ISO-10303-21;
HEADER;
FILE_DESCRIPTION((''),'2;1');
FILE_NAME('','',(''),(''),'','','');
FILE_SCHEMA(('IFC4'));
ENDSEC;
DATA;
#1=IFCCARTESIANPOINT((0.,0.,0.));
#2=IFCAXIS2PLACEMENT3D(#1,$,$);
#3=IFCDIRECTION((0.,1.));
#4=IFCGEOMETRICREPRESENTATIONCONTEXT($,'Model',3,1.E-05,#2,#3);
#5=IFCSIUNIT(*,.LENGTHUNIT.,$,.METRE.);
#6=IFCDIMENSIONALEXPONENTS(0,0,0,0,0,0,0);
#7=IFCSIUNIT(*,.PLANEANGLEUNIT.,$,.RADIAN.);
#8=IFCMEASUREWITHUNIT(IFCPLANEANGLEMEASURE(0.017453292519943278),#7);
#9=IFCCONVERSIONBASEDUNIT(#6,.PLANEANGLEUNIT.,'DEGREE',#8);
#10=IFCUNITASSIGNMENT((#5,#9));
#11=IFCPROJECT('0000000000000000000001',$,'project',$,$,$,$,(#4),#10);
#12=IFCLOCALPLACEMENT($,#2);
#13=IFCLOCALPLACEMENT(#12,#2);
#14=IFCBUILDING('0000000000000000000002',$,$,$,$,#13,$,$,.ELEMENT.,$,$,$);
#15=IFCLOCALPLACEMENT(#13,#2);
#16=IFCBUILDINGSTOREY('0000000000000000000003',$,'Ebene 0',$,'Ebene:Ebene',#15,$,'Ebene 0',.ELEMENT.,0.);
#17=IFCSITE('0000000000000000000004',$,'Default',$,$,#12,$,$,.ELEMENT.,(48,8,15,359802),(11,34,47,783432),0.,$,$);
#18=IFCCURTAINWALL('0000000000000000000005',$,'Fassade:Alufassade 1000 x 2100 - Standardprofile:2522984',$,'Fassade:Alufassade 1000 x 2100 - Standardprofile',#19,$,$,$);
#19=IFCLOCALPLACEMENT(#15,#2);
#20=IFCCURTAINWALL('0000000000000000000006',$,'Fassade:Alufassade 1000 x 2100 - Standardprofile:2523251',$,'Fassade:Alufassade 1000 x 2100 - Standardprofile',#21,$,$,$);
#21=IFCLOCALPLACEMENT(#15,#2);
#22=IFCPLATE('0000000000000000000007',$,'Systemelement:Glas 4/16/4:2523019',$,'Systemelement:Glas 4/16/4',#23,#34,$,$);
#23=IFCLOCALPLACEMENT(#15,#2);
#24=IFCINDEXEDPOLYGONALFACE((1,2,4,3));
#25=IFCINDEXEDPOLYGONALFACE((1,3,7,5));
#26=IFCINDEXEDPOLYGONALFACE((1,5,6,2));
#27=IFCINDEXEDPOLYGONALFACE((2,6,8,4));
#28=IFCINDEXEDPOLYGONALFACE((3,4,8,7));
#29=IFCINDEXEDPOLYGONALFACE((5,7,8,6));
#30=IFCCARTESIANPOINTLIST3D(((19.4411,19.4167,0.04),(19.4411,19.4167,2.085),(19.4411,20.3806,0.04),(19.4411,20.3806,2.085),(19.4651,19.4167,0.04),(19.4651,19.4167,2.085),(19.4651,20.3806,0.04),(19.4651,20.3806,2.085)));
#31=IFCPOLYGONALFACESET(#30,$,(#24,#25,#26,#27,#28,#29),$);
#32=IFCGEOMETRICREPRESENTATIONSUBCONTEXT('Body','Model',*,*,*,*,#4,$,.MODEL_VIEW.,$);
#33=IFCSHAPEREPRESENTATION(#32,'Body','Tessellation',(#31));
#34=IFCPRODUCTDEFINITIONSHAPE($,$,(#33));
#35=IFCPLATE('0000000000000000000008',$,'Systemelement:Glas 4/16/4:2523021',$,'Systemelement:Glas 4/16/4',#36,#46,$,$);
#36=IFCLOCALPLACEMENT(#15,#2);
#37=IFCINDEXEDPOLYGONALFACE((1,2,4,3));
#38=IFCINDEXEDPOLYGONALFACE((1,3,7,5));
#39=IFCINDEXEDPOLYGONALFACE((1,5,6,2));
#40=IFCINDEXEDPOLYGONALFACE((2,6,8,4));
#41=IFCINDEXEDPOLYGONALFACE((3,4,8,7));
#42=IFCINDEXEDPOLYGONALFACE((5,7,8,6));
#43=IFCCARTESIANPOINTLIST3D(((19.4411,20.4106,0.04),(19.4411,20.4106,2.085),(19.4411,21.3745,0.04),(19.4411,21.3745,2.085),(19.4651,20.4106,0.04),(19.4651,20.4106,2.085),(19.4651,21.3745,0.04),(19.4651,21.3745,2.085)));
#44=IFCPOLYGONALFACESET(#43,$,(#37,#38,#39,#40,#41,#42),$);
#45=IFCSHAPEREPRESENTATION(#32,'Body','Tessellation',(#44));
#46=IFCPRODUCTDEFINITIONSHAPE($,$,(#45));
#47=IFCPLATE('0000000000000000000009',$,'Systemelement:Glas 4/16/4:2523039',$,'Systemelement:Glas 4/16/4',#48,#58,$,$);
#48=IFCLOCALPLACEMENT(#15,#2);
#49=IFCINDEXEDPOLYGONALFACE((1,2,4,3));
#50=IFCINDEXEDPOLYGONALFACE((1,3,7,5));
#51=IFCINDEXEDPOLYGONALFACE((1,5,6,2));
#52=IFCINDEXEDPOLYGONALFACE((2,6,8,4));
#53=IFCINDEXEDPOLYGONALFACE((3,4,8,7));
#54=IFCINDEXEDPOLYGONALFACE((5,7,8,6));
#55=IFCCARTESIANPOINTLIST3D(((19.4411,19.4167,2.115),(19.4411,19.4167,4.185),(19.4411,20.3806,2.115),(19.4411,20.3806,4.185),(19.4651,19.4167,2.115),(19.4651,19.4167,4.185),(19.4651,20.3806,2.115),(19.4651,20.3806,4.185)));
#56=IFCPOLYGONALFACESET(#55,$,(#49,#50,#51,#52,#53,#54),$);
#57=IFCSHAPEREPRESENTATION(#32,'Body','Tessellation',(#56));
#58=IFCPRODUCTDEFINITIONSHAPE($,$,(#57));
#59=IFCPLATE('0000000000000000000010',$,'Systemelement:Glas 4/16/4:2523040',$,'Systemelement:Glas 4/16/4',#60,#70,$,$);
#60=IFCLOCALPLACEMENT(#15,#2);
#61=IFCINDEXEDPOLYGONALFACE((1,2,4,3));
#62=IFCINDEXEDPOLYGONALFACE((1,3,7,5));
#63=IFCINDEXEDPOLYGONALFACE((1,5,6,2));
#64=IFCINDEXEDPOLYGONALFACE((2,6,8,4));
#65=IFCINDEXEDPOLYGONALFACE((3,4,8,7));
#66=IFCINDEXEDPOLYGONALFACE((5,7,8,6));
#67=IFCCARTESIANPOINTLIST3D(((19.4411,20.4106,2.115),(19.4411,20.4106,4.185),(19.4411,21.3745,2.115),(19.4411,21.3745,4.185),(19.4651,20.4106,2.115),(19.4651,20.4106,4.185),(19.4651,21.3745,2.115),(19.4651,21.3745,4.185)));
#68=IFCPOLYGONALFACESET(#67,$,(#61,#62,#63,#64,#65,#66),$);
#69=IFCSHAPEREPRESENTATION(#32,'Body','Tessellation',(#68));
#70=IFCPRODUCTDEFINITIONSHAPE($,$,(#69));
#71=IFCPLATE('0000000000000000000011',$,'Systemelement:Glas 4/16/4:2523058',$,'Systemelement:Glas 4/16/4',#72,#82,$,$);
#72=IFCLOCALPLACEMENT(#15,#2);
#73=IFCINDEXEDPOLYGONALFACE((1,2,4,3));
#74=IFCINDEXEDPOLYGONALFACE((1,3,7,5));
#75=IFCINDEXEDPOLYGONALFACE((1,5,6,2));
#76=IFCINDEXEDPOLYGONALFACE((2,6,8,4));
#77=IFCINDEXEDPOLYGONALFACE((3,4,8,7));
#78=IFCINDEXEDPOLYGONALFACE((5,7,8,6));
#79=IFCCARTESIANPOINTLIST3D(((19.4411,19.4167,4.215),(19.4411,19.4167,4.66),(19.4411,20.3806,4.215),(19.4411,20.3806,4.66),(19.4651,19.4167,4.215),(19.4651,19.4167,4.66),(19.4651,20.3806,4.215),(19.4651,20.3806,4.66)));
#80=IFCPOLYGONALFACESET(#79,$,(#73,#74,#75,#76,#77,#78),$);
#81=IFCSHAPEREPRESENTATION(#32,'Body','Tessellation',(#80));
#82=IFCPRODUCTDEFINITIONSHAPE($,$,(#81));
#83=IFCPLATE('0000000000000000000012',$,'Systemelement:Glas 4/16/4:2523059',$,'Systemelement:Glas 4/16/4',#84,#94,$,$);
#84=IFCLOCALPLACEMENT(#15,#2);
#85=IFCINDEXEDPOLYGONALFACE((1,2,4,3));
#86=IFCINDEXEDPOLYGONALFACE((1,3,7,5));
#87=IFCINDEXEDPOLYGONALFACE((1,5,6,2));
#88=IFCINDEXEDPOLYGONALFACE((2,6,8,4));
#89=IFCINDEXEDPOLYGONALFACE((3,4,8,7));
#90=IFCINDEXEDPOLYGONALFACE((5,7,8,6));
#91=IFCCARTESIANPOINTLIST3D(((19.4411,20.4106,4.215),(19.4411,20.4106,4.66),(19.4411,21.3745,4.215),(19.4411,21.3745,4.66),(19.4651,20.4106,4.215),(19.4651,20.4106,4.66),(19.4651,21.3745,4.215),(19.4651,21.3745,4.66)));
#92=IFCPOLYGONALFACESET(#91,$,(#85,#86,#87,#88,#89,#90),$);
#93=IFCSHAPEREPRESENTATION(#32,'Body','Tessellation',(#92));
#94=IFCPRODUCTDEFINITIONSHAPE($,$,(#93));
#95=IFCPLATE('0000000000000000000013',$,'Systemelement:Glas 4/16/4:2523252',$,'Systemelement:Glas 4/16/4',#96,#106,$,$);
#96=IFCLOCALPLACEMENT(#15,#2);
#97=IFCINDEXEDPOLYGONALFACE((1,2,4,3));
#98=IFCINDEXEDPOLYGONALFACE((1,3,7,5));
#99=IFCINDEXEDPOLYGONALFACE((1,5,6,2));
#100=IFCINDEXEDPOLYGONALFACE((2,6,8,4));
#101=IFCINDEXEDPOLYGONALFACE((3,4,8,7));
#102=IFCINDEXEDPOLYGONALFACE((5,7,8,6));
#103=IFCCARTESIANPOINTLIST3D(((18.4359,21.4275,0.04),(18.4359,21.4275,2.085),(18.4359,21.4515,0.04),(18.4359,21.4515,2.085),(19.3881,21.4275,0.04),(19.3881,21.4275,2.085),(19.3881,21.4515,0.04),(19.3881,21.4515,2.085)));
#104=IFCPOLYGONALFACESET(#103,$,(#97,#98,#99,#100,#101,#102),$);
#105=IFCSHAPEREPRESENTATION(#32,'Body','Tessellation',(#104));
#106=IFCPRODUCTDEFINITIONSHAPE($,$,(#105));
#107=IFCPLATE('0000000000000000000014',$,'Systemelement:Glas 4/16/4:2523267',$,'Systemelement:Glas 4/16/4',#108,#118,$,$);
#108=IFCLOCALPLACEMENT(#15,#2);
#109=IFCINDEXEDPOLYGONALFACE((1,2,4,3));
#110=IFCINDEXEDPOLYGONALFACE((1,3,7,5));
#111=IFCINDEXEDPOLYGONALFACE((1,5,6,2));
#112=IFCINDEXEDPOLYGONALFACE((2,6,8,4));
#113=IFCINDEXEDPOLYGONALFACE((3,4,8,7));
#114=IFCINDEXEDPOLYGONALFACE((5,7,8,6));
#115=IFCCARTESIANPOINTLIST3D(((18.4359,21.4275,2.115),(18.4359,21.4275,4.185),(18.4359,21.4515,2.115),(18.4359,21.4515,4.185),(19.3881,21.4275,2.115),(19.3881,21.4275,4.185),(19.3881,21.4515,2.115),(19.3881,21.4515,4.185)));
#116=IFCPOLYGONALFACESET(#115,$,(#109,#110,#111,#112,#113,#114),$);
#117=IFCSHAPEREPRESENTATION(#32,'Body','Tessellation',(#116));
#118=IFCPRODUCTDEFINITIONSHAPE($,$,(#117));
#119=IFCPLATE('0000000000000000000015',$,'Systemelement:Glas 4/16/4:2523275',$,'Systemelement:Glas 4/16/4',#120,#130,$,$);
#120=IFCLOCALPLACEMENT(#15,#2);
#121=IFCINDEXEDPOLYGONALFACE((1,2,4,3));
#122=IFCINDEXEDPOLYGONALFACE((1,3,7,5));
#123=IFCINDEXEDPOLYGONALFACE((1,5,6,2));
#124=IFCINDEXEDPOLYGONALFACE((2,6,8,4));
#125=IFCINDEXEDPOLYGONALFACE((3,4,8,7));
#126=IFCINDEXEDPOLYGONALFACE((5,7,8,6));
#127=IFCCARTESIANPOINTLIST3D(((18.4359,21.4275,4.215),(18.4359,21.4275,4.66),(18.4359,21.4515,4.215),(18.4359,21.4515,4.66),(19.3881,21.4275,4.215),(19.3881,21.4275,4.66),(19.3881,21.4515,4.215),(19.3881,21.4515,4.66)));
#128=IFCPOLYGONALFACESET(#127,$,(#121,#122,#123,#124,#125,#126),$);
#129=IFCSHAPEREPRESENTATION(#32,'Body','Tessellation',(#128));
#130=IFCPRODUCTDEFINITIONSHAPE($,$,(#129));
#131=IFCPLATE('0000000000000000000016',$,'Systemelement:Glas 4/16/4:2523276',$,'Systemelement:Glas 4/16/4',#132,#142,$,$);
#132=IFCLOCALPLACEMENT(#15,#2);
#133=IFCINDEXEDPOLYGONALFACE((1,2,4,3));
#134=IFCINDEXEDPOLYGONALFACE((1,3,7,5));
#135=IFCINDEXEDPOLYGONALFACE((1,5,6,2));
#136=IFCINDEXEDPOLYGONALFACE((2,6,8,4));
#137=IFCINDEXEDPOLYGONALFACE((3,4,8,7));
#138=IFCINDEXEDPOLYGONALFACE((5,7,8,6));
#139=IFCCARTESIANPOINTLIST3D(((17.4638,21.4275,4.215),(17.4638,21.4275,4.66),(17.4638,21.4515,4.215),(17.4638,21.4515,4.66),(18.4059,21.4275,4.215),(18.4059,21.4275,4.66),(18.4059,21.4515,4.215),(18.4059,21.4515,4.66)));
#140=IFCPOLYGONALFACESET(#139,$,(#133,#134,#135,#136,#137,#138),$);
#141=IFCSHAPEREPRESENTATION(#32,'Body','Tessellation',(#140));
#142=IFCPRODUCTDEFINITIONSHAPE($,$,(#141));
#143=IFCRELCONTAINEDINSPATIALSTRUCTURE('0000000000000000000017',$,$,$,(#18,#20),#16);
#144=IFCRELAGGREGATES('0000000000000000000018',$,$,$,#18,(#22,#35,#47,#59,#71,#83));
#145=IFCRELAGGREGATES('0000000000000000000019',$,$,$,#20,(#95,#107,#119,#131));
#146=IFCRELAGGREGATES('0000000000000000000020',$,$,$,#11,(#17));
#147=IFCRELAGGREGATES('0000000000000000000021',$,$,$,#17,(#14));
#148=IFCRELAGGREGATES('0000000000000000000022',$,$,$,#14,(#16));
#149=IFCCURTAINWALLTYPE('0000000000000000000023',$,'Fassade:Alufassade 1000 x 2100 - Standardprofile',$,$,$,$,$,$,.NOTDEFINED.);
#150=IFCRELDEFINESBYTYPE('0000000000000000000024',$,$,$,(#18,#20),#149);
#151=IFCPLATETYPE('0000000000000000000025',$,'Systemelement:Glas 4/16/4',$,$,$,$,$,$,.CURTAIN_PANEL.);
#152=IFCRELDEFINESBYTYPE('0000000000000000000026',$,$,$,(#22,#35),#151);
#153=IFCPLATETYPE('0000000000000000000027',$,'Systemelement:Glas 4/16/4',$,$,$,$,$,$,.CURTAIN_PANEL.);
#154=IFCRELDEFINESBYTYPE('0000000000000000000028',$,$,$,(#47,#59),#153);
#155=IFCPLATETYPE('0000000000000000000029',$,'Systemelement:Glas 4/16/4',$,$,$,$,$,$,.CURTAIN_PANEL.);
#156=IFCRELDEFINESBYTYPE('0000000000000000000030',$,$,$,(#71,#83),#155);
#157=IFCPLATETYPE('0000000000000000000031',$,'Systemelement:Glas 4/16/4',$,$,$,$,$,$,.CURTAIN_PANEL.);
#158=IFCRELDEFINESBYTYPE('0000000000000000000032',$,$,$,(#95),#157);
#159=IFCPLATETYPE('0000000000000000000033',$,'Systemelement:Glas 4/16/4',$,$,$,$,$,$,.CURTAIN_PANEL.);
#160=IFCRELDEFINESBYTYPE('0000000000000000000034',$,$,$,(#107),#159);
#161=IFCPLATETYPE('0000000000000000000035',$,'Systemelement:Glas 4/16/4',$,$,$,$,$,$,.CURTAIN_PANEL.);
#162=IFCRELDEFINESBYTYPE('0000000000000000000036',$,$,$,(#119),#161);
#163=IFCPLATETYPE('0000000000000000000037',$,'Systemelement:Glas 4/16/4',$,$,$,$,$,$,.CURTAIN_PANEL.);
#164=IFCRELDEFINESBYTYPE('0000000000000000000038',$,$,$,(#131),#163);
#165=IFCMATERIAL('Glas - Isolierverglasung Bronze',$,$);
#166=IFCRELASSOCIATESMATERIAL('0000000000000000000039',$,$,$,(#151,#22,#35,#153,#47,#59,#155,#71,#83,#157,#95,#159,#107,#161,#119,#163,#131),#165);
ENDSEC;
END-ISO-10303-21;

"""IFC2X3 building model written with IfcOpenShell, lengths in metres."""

from ifc_helpers import new_model, entity, si_unit, converted_unit, direction, frame, origin, origin_2d_with_axis, place, context, subcontext, project, spatial, rectangle, extrude, source, transform, mapped, material, type_object, type_shapes, element, aggregate, save


model = new_model("IFC2X3")

# Units and contexts
model_context = context("Model", 3, precision=1e-05, world=origin(), true_north=direction((0.0, 1.0)))
body_context = subcontext(model_context, "Body", "Model", "MODEL_VIEW")
ifc_project = project(units=[si_unit("LENGTHUNIT", "METRE"), converted_unit("PLANEANGLEUNIT", "DEGREE", entity("IfcPlaneAngleMeasure", 0.017453292519943278), si_unit("PLANEANGLEUNIT", "RADIAN"), dimensions=[0, 0, 0, 0, 0, 0, 0])], contexts=[model_context])

# Site, building, storey
site_placement = place(None, origin())
site = spatial("IfcSite", under=ifc_project, at=site_placement, Name="Default", CompositionType="ELEMENT", RefLatitude=(48, 8, 15, 359802), RefLongitude=(11, 34, 47, 783432), RefElevation=0.0)
building_placement = place(site_placement, origin())
building = spatial("IfcBuilding", under=site, at=building_placement, CompositionType="ELEMENT")
storey_placement = place(building_placement, origin())
storey = spatial("IfcBuildingStorey", under=building, at=storey_placement, Name="Ebene 0", ObjectType="Ebene:Ebene", LongName="Ebene 0", CompositionType="ELEMENT", Elevation=0.0)

# Curtain walls
curtain_wall_type = type_object("IfcCurtainWallType", Name="Fassade:Alufassade 1000 x 2100 - Standardprofile", PredefinedType="NOTDEFINED")
curtain_wall_1_placement = place(storey_placement, origin())
curtain_wall_1 = element("IfcCurtainWall", 1, at=curtain_wall_1_placement, inside=storey, type_object=curtain_wall_type, Name="Fassade:Alufassade 1000 x 2100 - Standardprofile:2522984", ObjectType="Fassade:Alufassade 1000 x 2100 - Standardprofile")
curtain_wall_2_placement = place(storey_placement, origin())
curtain_wall_2 = element("IfcCurtainWall", 2, at=curtain_wall_2_placement, inside=storey, type_object=curtain_wall_type, Name="Fassade:Alufassade 1000 x 2100 - Standardprofile:2523251", ObjectType="Fassade:Alufassade 1000 x 2100 - Standardprofile")

# Plates
ifc_material_1 = material(Name="Glas - Isolierverglasung Bronze")
plate_type_1 = type_object("IfcPlateType", Name="Systemelement:Glas 4/16/4", PredefinedType="CURTAIN_PANEL", material=ifc_material_1)
shared_shape_1 = source(origin(), body_context, "Body", "SweptSolid", [
    extrude(rectangle(XDim=0.024, YDim=0.9639, at=origin_2d_with_axis()), frame((0.0, 0.0, 0.0), z_axis=(0.0, 0.0, 1.0), x_axis=(0.0, 1.0, 0.0)), (0.0, 0.0, 1.0), 2.045),
])
type_shapes(plate_type_1, [shared_shape_1])
plate_1_placement = place(curtain_wall_1_placement, frame((19.4531, 19.8987, 0.04), z_axis=(0.0, 0.0, 1.0), x_axis=(0.0, 1.0, 0.0)))
plate_1 = element("IfcPlate", 3, at=plate_1_placement, type_object=plate_type_1, material=ifc_material_1, Name="Systemelement:Glas 4/16/4:2523019", ObjectType="Systemelement:Glas 4/16/4", context=body_context, shape_type="MappedRepresentation", body=[
    mapped(shared_shape_1, transform((0.0, 0.0, 0.0), scale=1.0)),
])
plate_2_placement = place(curtain_wall_1_placement, frame((19.4531, 20.8926, 0.04), z_axis=(0.0, 0.0, 1.0), x_axis=(0.0, 1.0, 0.0)))
plate_2 = element("IfcPlate", 4, at=plate_2_placement, type_object=plate_type_1, material=ifc_material_1, Name="Systemelement:Glas 4/16/4:2523021", ObjectType="Systemelement:Glas 4/16/4", context=body_context, shape_type="MappedRepresentation", body=[
    mapped(shared_shape_1, transform((0.0, 0.0, 0.0), scale=1.0)),
])
plate_type_2 = type_object("IfcPlateType", Name="Systemelement:Glas 4/16/4", PredefinedType="CURTAIN_PANEL", material=ifc_material_1)
shared_shape_2 = source(origin(), body_context, "Body", "SweptSolid", [
    extrude(rectangle(XDim=0.024, YDim=0.9639, at=origin_2d_with_axis()), frame((0.0, 0.0, 0.0), z_axis=(0.0, 0.0, 1.0), x_axis=(0.0, 1.0, 0.0)), (0.0, 0.0, 1.0), 2.07),
])
type_shapes(plate_type_2, [shared_shape_2])
plate_3_placement = place(curtain_wall_1_placement, frame((19.4531, 19.8987, 2.115), z_axis=(0.0, 0.0, 1.0), x_axis=(0.0, 1.0, 0.0)))
plate_3 = element("IfcPlate", 5, at=plate_3_placement, type_object=plate_type_2, material=ifc_material_1, Name="Systemelement:Glas 4/16/4:2523039", ObjectType="Systemelement:Glas 4/16/4", context=body_context, shape_type="MappedRepresentation", body=[
    mapped(shared_shape_2, transform((0.0, 0.0, 0.0), scale=1.0)),
])
plate_4_placement = place(curtain_wall_1_placement, frame((19.4531, 20.8926, 2.115), z_axis=(0.0, 0.0, 1.0), x_axis=(0.0, 1.0, 0.0)))
plate_4 = element("IfcPlate", 6, at=plate_4_placement, type_object=plate_type_2, material=ifc_material_1, Name="Systemelement:Glas 4/16/4:2523040", ObjectType="Systemelement:Glas 4/16/4", context=body_context, shape_type="MappedRepresentation", body=[
    mapped(shared_shape_2, transform((0.0, 0.0, 0.0), scale=1.0)),
])
plate_type_3 = type_object("IfcPlateType", Name="Systemelement:Glas 4/16/4", PredefinedType="CURTAIN_PANEL", material=ifc_material_1)
shared_shape_3 = source(origin(), body_context, "Body", "SweptSolid", [
    extrude(rectangle(XDim=0.024, YDim=0.9639, at=origin_2d_with_axis()), frame((0.0, 0.0, 0.0), z_axis=(0.0, 0.0, 1.0), x_axis=(0.0, 1.0, 0.0)), (0.0, 0.0, 1.0), 0.445),
])
type_shapes(plate_type_3, [shared_shape_3])
plate_5_placement = place(curtain_wall_1_placement, frame((19.4531, 19.8987, 4.215), z_axis=(0.0, 0.0, 1.0), x_axis=(0.0, 1.0, 0.0)))
plate_5 = element("IfcPlate", 7, at=plate_5_placement, type_object=plate_type_3, material=ifc_material_1, Name="Systemelement:Glas 4/16/4:2523058", ObjectType="Systemelement:Glas 4/16/4", context=body_context, shape_type="MappedRepresentation", body=[
    mapped(shared_shape_3, transform((0.0, 0.0, 0.0), scale=1.0)),
])
plate_6_placement = place(curtain_wall_1_placement, frame((19.4531, 20.8926, 4.215), z_axis=(0.0, 0.0, 1.0), x_axis=(0.0, 1.0, 0.0)))
plate_6 = element("IfcPlate", 8, at=plate_6_placement, type_object=plate_type_3, material=ifc_material_1, Name="Systemelement:Glas 4/16/4:2523059", ObjectType="Systemelement:Glas 4/16/4", context=body_context, shape_type="MappedRepresentation", body=[
    mapped(shared_shape_3, transform((0.0, 0.0, 0.0), scale=1.0)),
])
aggregate(curtain_wall_1, [plate_1, plate_2, plate_3, plate_4, plate_5, plate_6])
plate_type_4 = type_object("IfcPlateType", Name="Systemelement:Glas 4/16/4", PredefinedType="CURTAIN_PANEL", material=ifc_material_1)
shared_shape_4 = source(origin(), body_context, "Body", "SweptSolid", [
    extrude(rectangle(XDim=0.024, YDim=0.9521, at=origin_2d_with_axis()), frame((0.0, 0.0, 0.0), z_axis=(0.0, 0.0, 1.0), x_axis=(0.0, 1.0, 0.0)), (0.0, 0.0, 1.0), 2.045),
])
type_shapes(plate_type_4, [shared_shape_4])
plate_7_placement = place(curtain_wall_2_placement, frame((18.912, 21.4395, 0.04), z_axis=(0.0, 0.0, 1.0), x_axis=(-1.0, 0.0, 0.0)))
plate_7 = element("IfcPlate", 9, at=plate_7_placement, type_object=plate_type_4, material=ifc_material_1, Name="Systemelement:Glas 4/16/4:2523252", ObjectType="Systemelement:Glas 4/16/4", context=body_context, shape_type="MappedRepresentation", body=[
    mapped(shared_shape_4, transform((0.0, 0.0, 0.0), scale=1.0)),
])
plate_type_5 = type_object("IfcPlateType", Name="Systemelement:Glas 4/16/4", PredefinedType="CURTAIN_PANEL", material=ifc_material_1)
shared_shape_5 = source(origin(), body_context, "Body", "SweptSolid", [
    extrude(rectangle(XDim=0.024, YDim=0.9521, at=origin_2d_with_axis()), frame((0.0, 0.0, 0.0), z_axis=(0.0, 0.0, 1.0), x_axis=(0.0, 1.0, 0.0)), (0.0, 0.0, 1.0), 2.07),
])
type_shapes(plate_type_5, [shared_shape_5])
plate_8_placement = place(curtain_wall_2_placement, frame((18.912, 21.4395, 2.115), z_axis=(0.0, 0.0, 1.0), x_axis=(-1.0, 0.0, 0.0)))
plate_8 = element("IfcPlate", 10, at=plate_8_placement, type_object=plate_type_5, material=ifc_material_1, Name="Systemelement:Glas 4/16/4:2523267", ObjectType="Systemelement:Glas 4/16/4", context=body_context, shape_type="MappedRepresentation", body=[
    mapped(shared_shape_5, transform((0.0, 0.0, 0.0), scale=1.0)),
])
plate_type_6 = type_object("IfcPlateType", Name="Systemelement:Glas 4/16/4", PredefinedType="CURTAIN_PANEL", material=ifc_material_1)
shared_shape_6 = source(origin(), body_context, "Body", "SweptSolid", [
    extrude(rectangle(XDim=0.024, YDim=0.9521, at=origin_2d_with_axis()), frame((0.0, 0.0, 0.0), z_axis=(0.0, 0.0, 1.0), x_axis=(0.0, 1.0, 0.0)), (0.0, 0.0, 1.0), 0.445),
])
type_shapes(plate_type_6, [shared_shape_6])
plate_9_placement = place(curtain_wall_2_placement, frame((18.912, 21.4395, 4.215), z_axis=(0.0, 0.0, 1.0), x_axis=(-1.0, 0.0, 0.0)))
plate_9 = element("IfcPlate", 11, at=plate_9_placement, type_object=plate_type_6, material=ifc_material_1, Name="Systemelement:Glas 4/16/4:2523275", ObjectType="Systemelement:Glas 4/16/4", context=body_context, shape_type="MappedRepresentation", body=[
    mapped(shared_shape_6, transform((0.0, 0.0, 0.0), scale=1.0)),
])
plate_type_7 = type_object("IfcPlateType", Name="Systemelement:Glas 4/16/4", PredefinedType="CURTAIN_PANEL", material=ifc_material_1)
shared_shape_7 = source(origin(), body_context, "Body", "SweptSolid", [
    extrude(rectangle(XDim=0.024, YDim=0.9421, at=origin_2d_with_axis()), frame((0.0, 0.0, 0.0), z_axis=(0.0, 0.0, 1.0), x_axis=(0.0, 1.0, 0.0)), (0.0, 0.0, 1.0), 0.445),
])
type_shapes(plate_type_7, [shared_shape_7])
plate_10_placement = place(curtain_wall_2_placement, frame((17.9349, 21.4395, 4.215), z_axis=(0.0, 0.0, 1.0), x_axis=(-1.0, 0.0, 0.0)))
plate_10 = element("IfcPlate", 12, at=plate_10_placement, type_object=plate_type_7, material=ifc_material_1, Name="Systemelement:Glas 4/16/4:2523276", ObjectType="Systemelement:Glas 4/16/4", context=body_context, shape_type="MappedRepresentation", body=[
    mapped(shared_shape_7, transform((0.0, 0.0, 0.0), scale=1.0)),
])
aggregate(curtain_wall_2, [plate_7, plate_8, plate_9, plate_10])

save(model, "model.ifc")
